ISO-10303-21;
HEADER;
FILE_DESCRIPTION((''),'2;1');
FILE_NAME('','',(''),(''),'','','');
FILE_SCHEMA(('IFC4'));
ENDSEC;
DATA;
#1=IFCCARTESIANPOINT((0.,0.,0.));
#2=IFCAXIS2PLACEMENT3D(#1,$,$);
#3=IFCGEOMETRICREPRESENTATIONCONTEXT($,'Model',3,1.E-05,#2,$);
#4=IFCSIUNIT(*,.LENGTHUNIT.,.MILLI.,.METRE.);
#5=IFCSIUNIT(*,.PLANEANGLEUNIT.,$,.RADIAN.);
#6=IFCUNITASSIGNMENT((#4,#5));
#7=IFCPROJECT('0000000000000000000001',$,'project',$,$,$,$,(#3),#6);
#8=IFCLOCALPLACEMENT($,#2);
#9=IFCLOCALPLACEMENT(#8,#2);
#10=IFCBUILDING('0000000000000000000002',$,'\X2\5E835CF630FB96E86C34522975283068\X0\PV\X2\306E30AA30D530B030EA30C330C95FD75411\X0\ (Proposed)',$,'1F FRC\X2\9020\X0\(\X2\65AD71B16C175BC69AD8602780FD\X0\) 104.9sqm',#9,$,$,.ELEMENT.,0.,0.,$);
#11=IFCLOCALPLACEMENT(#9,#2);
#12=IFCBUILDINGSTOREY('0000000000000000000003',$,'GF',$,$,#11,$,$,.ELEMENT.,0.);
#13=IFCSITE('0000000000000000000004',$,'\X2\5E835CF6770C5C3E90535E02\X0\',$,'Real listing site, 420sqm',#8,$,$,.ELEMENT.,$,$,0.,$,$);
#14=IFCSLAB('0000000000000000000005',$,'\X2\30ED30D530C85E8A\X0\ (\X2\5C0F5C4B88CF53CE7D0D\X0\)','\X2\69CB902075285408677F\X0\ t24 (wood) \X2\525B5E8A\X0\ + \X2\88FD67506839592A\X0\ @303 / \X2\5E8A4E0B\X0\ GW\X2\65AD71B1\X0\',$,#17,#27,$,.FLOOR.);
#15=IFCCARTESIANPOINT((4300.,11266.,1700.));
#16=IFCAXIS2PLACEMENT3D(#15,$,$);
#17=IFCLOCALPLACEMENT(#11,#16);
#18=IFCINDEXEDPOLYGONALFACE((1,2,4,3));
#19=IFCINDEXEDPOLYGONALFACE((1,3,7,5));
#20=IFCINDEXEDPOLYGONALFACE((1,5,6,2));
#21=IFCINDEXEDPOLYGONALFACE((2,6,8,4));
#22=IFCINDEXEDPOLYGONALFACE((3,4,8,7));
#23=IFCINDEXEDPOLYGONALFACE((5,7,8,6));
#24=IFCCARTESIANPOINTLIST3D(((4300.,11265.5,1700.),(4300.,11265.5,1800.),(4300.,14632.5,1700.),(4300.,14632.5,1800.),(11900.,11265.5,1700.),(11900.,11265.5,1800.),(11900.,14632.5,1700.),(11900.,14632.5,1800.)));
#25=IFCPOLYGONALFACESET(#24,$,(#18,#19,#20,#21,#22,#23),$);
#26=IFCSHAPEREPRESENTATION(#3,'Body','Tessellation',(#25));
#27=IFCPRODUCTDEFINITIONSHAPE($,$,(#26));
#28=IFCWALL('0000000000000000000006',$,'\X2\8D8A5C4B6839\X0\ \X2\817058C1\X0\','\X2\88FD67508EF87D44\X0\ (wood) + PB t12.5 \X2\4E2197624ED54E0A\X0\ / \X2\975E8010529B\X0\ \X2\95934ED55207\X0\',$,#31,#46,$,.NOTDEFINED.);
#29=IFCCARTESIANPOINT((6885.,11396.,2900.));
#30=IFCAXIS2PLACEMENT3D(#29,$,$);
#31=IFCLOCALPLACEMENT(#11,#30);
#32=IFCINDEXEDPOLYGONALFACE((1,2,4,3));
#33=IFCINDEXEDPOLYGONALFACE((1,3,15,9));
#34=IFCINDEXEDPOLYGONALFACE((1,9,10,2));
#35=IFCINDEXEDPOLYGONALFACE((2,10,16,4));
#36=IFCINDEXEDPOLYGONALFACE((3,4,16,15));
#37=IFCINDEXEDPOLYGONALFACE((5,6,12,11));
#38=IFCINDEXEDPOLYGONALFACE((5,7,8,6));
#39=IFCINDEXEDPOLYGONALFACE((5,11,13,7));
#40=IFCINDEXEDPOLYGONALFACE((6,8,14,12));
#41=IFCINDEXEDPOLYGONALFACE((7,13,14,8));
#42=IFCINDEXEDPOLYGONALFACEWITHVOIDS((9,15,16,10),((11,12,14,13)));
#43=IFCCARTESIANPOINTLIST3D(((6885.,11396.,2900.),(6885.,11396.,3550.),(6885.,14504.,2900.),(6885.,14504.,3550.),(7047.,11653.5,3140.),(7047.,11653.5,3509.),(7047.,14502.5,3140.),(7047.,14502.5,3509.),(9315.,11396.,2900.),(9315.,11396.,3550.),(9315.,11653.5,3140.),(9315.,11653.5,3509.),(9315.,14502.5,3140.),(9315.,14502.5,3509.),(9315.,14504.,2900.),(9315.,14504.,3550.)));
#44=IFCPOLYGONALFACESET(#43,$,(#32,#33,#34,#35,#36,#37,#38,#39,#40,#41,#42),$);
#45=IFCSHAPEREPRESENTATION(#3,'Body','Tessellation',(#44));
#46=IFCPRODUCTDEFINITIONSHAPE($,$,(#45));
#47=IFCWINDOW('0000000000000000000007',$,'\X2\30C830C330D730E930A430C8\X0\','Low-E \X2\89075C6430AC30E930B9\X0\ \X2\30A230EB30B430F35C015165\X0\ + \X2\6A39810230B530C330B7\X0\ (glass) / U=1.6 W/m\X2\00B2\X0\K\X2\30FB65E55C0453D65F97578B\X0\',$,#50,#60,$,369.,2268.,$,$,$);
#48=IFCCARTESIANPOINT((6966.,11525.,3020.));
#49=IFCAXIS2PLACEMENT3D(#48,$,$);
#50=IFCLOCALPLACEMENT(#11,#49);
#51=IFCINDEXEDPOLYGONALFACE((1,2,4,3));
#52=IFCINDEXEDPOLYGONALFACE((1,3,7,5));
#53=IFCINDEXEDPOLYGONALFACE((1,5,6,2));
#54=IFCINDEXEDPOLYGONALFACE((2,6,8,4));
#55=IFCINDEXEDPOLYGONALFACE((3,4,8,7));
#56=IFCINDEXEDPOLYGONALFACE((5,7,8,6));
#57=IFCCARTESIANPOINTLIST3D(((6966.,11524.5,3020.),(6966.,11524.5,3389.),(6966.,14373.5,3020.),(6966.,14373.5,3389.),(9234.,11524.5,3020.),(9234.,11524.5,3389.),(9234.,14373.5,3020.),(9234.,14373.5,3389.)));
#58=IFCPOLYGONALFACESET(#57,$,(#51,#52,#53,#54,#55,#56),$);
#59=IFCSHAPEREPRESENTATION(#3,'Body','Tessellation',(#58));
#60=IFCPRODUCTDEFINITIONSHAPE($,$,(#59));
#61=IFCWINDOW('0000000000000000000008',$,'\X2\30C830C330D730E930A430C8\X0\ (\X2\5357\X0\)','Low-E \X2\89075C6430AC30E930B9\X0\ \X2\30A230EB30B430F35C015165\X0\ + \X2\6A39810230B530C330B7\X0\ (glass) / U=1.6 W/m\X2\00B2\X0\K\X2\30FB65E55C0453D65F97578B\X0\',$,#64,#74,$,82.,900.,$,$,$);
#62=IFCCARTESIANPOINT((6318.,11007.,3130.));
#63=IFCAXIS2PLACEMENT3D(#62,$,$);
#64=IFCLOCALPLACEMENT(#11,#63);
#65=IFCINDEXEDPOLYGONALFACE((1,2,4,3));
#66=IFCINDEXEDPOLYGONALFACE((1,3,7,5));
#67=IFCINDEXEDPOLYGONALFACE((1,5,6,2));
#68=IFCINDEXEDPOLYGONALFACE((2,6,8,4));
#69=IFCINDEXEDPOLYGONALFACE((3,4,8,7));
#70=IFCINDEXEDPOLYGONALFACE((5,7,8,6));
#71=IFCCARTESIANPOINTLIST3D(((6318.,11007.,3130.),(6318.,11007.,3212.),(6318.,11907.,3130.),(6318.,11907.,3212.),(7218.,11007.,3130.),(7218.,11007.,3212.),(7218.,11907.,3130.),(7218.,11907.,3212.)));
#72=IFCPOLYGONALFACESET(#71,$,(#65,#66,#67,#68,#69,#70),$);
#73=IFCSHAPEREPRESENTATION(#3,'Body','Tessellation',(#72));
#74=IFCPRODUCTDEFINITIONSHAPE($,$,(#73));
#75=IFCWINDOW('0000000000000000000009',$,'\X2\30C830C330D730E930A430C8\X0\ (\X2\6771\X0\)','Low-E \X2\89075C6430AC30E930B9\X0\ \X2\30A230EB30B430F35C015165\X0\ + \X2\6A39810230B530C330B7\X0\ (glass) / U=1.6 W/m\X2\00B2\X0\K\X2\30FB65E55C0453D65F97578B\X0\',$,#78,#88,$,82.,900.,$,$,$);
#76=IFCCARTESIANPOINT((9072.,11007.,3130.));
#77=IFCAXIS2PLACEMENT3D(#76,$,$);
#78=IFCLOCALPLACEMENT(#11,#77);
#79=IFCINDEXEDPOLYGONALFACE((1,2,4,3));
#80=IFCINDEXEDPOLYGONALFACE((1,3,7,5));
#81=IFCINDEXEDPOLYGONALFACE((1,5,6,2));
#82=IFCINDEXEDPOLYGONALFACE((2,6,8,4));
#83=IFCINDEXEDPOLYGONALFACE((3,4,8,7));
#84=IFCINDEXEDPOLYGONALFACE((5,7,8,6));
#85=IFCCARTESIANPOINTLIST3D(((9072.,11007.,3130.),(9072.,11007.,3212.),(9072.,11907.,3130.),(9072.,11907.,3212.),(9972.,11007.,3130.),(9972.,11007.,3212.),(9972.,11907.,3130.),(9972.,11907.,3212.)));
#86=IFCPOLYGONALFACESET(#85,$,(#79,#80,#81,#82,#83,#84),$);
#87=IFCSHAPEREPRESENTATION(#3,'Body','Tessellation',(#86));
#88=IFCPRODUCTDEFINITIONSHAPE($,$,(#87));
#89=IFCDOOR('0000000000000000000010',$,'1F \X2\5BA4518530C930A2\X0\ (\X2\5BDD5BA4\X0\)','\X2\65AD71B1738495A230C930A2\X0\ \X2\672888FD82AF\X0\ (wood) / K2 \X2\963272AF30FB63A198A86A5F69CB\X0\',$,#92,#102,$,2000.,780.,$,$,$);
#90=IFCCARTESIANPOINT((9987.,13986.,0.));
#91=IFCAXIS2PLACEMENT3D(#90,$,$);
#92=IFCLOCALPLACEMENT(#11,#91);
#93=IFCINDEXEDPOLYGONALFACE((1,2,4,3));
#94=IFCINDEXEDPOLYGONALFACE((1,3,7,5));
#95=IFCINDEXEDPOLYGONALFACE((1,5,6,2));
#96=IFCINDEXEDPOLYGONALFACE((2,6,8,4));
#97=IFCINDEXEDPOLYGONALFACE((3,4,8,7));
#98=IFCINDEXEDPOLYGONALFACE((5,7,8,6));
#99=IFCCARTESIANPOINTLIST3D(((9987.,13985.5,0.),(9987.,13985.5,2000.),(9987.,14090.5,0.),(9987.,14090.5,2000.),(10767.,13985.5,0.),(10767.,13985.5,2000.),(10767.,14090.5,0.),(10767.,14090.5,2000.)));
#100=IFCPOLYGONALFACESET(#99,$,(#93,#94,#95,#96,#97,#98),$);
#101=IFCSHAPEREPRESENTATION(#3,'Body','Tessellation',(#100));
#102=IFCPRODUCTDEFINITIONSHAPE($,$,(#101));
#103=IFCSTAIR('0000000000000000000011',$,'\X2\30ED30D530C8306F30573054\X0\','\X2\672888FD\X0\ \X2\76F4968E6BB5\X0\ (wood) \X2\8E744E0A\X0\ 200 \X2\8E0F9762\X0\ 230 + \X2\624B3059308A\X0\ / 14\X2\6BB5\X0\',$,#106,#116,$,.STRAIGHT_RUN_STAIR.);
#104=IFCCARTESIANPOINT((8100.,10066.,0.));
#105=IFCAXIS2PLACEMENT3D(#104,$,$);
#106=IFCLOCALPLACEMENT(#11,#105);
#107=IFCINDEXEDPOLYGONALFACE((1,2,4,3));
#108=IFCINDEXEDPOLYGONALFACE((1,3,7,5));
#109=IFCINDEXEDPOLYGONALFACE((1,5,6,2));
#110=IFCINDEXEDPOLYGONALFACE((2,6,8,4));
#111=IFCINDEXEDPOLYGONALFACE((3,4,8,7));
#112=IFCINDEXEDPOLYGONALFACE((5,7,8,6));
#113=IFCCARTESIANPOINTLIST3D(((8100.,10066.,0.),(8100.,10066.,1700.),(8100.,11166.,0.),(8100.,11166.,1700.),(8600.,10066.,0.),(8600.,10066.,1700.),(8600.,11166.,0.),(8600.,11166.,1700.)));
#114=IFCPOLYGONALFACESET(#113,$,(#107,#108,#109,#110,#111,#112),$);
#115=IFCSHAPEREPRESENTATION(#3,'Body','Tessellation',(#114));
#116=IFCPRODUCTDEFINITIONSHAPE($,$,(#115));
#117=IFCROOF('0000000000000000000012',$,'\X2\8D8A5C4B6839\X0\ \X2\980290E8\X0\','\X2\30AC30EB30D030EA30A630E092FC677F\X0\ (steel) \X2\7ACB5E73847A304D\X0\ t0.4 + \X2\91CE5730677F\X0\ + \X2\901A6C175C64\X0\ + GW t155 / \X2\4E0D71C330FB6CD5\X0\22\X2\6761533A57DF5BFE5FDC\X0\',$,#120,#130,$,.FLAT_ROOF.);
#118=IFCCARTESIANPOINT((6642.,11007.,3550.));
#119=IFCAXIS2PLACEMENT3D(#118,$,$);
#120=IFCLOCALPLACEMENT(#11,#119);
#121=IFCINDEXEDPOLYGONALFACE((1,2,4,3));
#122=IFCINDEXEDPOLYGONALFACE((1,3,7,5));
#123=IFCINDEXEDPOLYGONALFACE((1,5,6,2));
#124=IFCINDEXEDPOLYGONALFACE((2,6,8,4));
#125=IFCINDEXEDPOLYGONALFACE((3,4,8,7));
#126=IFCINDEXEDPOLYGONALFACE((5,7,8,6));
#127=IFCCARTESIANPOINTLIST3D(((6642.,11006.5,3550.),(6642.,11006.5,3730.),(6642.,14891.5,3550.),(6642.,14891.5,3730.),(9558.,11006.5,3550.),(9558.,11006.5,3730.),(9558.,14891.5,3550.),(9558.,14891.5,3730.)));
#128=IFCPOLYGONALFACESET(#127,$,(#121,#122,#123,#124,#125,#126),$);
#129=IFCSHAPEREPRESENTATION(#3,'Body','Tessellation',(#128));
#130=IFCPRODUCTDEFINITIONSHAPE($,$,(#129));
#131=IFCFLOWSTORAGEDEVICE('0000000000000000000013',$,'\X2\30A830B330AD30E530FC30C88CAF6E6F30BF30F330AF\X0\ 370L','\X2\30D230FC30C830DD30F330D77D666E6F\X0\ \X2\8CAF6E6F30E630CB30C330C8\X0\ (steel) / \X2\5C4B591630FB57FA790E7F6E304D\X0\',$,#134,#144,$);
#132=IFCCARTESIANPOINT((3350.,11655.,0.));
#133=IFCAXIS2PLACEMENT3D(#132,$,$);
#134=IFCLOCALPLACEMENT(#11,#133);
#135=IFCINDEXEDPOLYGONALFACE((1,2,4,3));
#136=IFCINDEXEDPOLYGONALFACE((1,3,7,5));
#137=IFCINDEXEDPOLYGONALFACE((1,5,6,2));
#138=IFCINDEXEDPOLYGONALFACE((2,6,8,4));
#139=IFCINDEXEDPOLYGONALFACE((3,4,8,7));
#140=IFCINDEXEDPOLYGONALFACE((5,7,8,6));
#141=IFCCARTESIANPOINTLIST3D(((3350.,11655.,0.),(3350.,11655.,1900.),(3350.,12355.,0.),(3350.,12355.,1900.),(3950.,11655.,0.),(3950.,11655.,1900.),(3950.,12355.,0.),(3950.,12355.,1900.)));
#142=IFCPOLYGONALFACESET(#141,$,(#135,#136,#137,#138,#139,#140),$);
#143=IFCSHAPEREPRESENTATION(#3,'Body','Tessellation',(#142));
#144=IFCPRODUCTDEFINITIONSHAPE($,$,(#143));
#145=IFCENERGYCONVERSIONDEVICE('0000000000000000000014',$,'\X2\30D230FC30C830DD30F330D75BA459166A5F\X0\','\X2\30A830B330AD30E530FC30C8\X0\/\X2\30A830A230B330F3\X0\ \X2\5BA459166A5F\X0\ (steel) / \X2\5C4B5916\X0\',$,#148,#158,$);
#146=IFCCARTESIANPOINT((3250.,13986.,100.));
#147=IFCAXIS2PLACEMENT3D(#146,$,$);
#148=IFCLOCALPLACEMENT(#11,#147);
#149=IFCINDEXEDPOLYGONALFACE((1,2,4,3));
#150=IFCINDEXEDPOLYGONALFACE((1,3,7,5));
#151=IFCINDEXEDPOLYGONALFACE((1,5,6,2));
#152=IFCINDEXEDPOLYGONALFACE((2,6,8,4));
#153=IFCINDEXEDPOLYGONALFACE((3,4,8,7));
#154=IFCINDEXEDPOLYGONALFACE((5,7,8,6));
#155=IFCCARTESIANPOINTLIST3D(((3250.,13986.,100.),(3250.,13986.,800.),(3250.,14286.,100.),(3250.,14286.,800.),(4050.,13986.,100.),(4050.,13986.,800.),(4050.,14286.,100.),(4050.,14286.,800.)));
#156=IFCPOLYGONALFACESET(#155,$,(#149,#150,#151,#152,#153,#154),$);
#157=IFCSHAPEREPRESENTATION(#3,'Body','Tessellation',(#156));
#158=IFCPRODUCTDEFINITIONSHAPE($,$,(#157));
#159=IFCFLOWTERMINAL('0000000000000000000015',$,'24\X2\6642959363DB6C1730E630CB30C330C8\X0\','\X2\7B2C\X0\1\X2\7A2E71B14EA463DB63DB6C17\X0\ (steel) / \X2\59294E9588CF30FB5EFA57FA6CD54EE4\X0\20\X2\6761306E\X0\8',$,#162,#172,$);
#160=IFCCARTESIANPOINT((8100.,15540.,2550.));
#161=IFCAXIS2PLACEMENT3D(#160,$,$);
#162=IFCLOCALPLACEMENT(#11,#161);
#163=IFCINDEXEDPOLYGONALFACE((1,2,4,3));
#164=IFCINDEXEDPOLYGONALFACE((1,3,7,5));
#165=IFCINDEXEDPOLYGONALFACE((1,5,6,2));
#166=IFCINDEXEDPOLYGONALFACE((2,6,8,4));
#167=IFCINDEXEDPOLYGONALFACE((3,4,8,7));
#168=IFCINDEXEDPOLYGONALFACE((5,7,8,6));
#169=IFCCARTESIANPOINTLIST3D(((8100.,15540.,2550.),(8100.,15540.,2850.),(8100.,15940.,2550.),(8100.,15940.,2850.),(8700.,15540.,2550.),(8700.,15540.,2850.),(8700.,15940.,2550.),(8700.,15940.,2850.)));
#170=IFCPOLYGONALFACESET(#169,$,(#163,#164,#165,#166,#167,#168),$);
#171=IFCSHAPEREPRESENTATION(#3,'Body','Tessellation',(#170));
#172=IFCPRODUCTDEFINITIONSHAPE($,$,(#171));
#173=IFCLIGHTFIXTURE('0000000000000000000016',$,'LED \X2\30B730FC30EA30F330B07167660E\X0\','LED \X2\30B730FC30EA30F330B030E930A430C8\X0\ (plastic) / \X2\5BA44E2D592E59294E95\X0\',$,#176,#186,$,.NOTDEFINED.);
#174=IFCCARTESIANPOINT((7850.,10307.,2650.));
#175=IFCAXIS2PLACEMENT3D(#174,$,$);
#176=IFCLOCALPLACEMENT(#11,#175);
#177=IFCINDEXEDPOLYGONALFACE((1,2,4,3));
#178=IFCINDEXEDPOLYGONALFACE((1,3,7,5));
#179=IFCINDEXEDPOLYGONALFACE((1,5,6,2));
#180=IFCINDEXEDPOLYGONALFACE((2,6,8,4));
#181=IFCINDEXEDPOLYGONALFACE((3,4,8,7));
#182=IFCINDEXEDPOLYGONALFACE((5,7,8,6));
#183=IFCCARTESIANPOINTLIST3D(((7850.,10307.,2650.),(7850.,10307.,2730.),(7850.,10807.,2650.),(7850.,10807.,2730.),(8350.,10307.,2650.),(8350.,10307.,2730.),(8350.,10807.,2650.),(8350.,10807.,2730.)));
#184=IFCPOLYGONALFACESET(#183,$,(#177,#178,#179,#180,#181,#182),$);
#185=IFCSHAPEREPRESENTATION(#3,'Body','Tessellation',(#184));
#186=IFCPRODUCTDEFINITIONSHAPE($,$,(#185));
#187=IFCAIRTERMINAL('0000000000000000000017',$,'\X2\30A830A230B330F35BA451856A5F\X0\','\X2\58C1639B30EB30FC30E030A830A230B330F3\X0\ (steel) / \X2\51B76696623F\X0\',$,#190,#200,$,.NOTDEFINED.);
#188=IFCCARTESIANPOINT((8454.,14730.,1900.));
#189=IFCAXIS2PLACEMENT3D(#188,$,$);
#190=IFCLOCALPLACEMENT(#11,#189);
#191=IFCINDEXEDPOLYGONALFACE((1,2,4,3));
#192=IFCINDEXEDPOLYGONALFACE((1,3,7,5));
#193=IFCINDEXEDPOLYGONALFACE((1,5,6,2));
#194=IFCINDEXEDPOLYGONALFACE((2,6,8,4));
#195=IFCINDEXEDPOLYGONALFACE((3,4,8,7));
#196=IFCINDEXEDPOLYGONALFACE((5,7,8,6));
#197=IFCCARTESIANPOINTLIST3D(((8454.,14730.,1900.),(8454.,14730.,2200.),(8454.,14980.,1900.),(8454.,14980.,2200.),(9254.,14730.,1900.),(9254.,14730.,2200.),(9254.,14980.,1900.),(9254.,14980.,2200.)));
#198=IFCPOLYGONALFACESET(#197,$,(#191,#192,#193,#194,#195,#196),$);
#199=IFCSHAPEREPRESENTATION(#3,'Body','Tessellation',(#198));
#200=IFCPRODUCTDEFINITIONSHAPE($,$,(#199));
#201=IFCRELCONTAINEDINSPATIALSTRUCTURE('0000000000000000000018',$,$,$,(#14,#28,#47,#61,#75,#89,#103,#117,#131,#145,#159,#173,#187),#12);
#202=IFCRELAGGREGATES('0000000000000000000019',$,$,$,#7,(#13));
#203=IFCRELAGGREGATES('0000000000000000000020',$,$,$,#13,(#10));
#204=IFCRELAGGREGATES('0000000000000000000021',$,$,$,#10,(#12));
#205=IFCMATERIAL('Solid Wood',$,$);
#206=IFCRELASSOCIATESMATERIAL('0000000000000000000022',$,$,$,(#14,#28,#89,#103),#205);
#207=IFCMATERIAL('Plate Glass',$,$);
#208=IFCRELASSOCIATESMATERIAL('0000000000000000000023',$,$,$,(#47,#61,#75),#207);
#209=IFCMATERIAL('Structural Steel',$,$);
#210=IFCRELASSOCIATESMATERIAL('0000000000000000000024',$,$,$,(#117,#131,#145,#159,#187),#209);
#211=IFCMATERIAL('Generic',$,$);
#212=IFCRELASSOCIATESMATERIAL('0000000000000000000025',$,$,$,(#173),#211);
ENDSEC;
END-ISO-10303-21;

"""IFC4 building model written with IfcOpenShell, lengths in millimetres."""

from ifc_helpers import new_model, si_unit, frame, frame_2d, origin, place, context, project, spatial, rectangle, extrude, material, element, fill, save


model = new_model("IFC4")

# Units and contexts
model_context = context("Model", 3, precision=1e-05, world=origin())
ifc_project = project(units=[si_unit("LENGTHUNIT", "METRE", prefix="MILLI"), si_unit("PLANEANGLEUNIT", "RADIAN")], contexts=[model_context])

# Site, building, storey
site_placement = place(None, origin())
site = spatial("IfcSite", under=ifc_project, at=site_placement, Name="広島県尾道市", ObjectType="Real listing site, 420sqm", CompositionType="ELEMENT", RefElevation=0.0)
building_placement = place(site_placement, origin())
building = spatial("IfcBuilding", under=site, at=building_placement, Name="広島・雨水利用とPVのオフグリッド志向 (Proposed)", ObjectType="1F FRC造(断熱気密高性能) 104.9sqm", CompositionType="ELEMENT", ElevationOfRefHeight=0.0, ElevationOfTerrain=0.0)
storey_placement = place(building_placement, origin())
storey = spatial("IfcBuildingStorey", under=building, at=storey_placement, Name="GF", CompositionType="ELEMENT", Elevation=0.0)

# Shared definitions
ifc_material_1 = material(Name="Solid Wood")

# Slab
slab_placement = place(storey_placement, frame((4300.0, 11266.0, 1700.0)))
element("IfcSlab", 1, at=slab_placement, inside=storey, material=ifc_material_1, Name="ロフト床 (小屋裏収納)", Description="構造用合板 t24 (wood) 剛床 + 製材根太 @303 / 床下 GW断熱", PredefinedType="FLOOR", context=model_context, shape_type="SweptSolid", body=[
    extrude(rectangle(XDim=7600.0, YDim=3367.0, at=frame_2d((3800.0, 1683.0))), frame((4300.0, 11266.0, 1700.0)), (0.0, 0.0, 1.0), 100.0),
])

# Wall, openings, windows
wall_1_placement = place(storey_placement, frame((6885.0, 11396.0, 2900.0)))
wall_1 = element("IfcWall", 2, at=wall_1_placement, inside=storey, material=ifc_material_1, Name="越屋根 腰壁", Description="製材軸組 (wood) + PB t12.5 両面仕上 / 非耐力 間仕切", PredefinedType="NOTDEFINED", context=model_context, shape_type="SweptSolid", body=[
    extrude(rectangle(XDim=2430.0, YDim=3108.0, at=frame_2d((1215.0, 1554.0))), frame((6885.0, 11396.0, 2900.0)), (0.0, 0.0, 1.0), 650.0),
])
opening_1_placement = place(storey_placement, frame((6966.0, 11525.0, 3020.0)))
opening_1 = element("IfcOpeningElement", 3, at=opening_1_placement, cuts=wall_1, PredefinedType="NOTDEFINED", context=model_context, shape_type="SweptSolid", body=[
    extrude(rectangle(XDim=2268.0, YDim=2849.0, at=frame_2d((1134.0, 1424.0))), frame((6966.0, 11525.0, 3020.0)), (0.0, 0.0, 1.0), 369.0),
])
opening_2_placement = place(storey_placement, frame((6318.0, 11007.0, 3130.0)))
opening_2 = element("IfcOpeningElement", 4, at=opening_2_placement, cuts=wall_1, PredefinedType="NOTDEFINED", context=model_context, shape_type="SweptSolid", body=[
    extrude(rectangle(XDim=900.0, YDim=900.0, at=frame_2d((450.0, 450.0))), frame((6318.0, 11007.0, 3130.0)), (0.0, 0.0, 1.0), 82.0),
])
opening_3_placement = place(storey_placement, frame((9072.0, 11007.0, 3130.0)))
opening_3 = element("IfcOpeningElement", 5, at=opening_3_placement, cuts=wall_1, PredefinedType="NOTDEFINED", context=model_context, shape_type="SweptSolid", body=[
    extrude(rectangle(XDim=900.0, YDim=900.0, at=frame_2d((450.0, 450.0))), frame((9072.0, 11007.0, 3130.0)), (0.0, 0.0, 1.0), 82.0),
])
ifc_material_2 = material(Name="Plate Glass")
window_1_placement = place(storey_placement, frame((6966.0, 11525.0, 3020.0)))
window_1 = element("IfcWindow", 6, at=window_1_placement, inside=storey, material=ifc_material_2, Name="トップライト", Description="Low-E 複層ガラス アルゴン封入 + 樹脂サッシ (glass) / U=1.6 W/m²K・日射取得型", OverallHeight=369.0, OverallWidth=2268.0, context=model_context, shape_type="SweptSolid", body=[
    extrude(rectangle(XDim=2268.0, YDim=2849.0, at=frame_2d((1134.0, 1424.0))), frame((6966.0, 11525.0, 3020.0)), (0.0, 0.0, 1.0), 369.0),
])
fill(opening_1, window_1)
window_2_placement = place(storey_placement, frame((6318.0, 11007.0, 3130.0)))
window_2 = element("IfcWindow", 7, at=window_2_placement, inside=storey, material=ifc_material_2, Name="トップライト (南)", Description="Low-E 複層ガラス アルゴン封入 + 樹脂サッシ (glass) / U=1.6 W/m²K・日射取得型", OverallHeight=82.0, OverallWidth=900.0, context=model_context, shape_type="SweptSolid", body=[
    extrude(rectangle(XDim=900.0, YDim=900.0, at=frame_2d((450.0, 450.0))), frame((6318.0, 11007.0, 3130.0)), (0.0, 0.0, 1.0), 82.0),
])
fill(opening_2, window_2)
window_3_placement = place(storey_placement, frame((9072.0, 11007.0, 3130.0)))
window_3 = element("IfcWindow", 8, at=window_3_placement, inside=storey, material=ifc_material_2, Name="トップライト (東)", Description="Low-E 複層ガラス アルゴン封入 + 樹脂サッシ (glass) / U=1.6 W/m²K・日射取得型", OverallHeight=82.0, OverallWidth=900.0, context=model_context, shape_type="SweptSolid", body=[
    extrude(rectangle(XDim=900.0, YDim=900.0, at=frame_2d((450.0, 450.0))), frame((9072.0, 11007.0, 3130.0)), (0.0, 0.0, 1.0), 82.0),
])
fill(opening_3, window_3)

# Door
door_1_placement = place(storey_placement, frame((9987.0, 13986.0, 0.0)))
element("IfcDoor", 9, at=door_1_placement, inside=storey, material=ifc_material_1, Name="1F 室内ドア (寝室)", Description="断熱玄関ドア 木製芯 (wood) / K2 防犯・採風機構", OverallHeight=2000.0, OverallWidth=780.0, context=model_context, shape_type="SweptSolid", body=[
    extrude(rectangle(XDim=780.0, YDim=105.0, at=frame_2d((390.0, 52.0))), frame((9987.0, 13986.0, 0.0)), (0.0, 0.0, 1.0), 2000.0),
])

# Stair
stair_placement = place(storey_placement, frame((8100.0, 10066.0, 0.0)))
element("IfcStair", 10, at=stair_placement, inside=storey, material=ifc_material_1, Name="ロフトはしご", Description="木製 直階段 (wood) 蹴上 200 踏面 230 + 手すり / 14段", PredefinedType="STRAIGHT_RUN_STAIR", context=model_context, shape_type="SweptSolid", body=[
    extrude(rectangle(XDim=500.0, YDim=1100.0, at=frame_2d((250.0, 550.0))), frame((8100.0, 10066.0, 0.0)), (0.0, 0.0, 1.0), 1700.0),
])

# Roof
ifc_material_3 = material(Name="Structural Steel")
roof_placement = place(storey_placement, frame((6642.0, 11007.0, 3550.0)))
element("IfcRoof", 11, at=roof_placement, inside=storey, material=ifc_material_3, Name="越屋根 頂部", Description="ガルバリウム鋼板 (steel) 立平葺き t0.4 + 野地板 + 通気層 + GW t155 / 不燃・法22条区域対応", PredefinedType="FLAT_ROOF", context=model_context, shape_type="SweptSolid", body=[
    extrude(rectangle(XDim=2916.0, YDim=3885.0, at=frame_2d((1458.0, 1942.0))), frame((6642.0, 11007.0, 3550.0)), (0.0, 0.0, 1.0), 180.0),
])

# Flow storage device
flow_storage_device_placement = place(storey_placement, frame((3350.0, 11655.0, 0.0)))
element("IfcFlowStorageDevice", 12, at=flow_storage_device_placement, inside=storey, material=ifc_material_3, Name="エコキュート貯湯タンク 370L", Description="ヒートポンプ給湯 貯湯ユニット (steel) / 屋外・基礎置き", context=model_context, shape_type="SweptSolid", body=[
    extrude(rectangle(XDim=600.0, YDim=700.0, at=frame_2d((300.0, 350.0))), frame((3350.0, 11655.0, 0.0)), (0.0, 0.0, 1.0), 1900.0),
])

# Energy conversion device
energy_conversion_device_placement = place(storey_placement, frame((3250.0, 13986.0, 100.0)))
element("IfcEnergyConversionDevice", 13, at=energy_conversion_device_placement, inside=storey, material=ifc_material_3, Name="ヒートポンプ室外機", Description="エコキュート/エアコン 室外機 (steel) / 屋外", context=model_context, shape_type="SweptSolid", body=[
    extrude(rectangle(XDim=800.0, YDim=300.0, at=frame_2d((400.0, 150.0))), frame((3250.0, 13986.0, 100.0)), (0.0, 0.0, 1.0), 700.0),
])

# Flow terminal
flow_terminal_placement = place(storey_placement, frame((8100.0, 15540.0, 2550.0)))
element("IfcFlowTerminal", 14, at=flow_terminal_placement, inside=storey, material=ifc_material_3, Name="24時間換気ユニット", Description="第1種熱交換換気 (steel) / 天井裏・建基法令20条の8", context=model_context, shape_type="SweptSolid", body=[
    extrude(rectangle(XDim=600.0, YDim=400.0, at=frame_2d((300.0, 200.0))), frame((8100.0, 15540.0, 2550.0)), (0.0, 0.0, 1.0), 300.0),
])

# Light fixture
ifc_material_4 = material(Name="Generic")
light_fixture_placement = place(storey_placement, frame((7850.0, 10307.0, 2650.0)))
element("IfcLightFixture", 15, at=light_fixture_placement, inside=storey, material=ifc_material_4, Name="LED シーリング照明", Description="LED シーリングライト (plastic) / 室中央天井", PredefinedType="NOTDEFINED", context=model_context, shape_type="SweptSolid", body=[
    extrude(rectangle(XDim=500.0, YDim=500.0, at=frame_2d((250.0, 250.0))), frame((7850.0, 10307.0, 2650.0)), (0.0, 0.0, 1.0), 80.0),
])

# Air terminal
air_terminal_placement = place(storey_placement, frame((8454.0, 14730.0, 1900.0)))
element("IfcAirTerminal", 16, at=air_terminal_placement, inside=storey, material=ifc_material_3, Name="エアコン室内機", Description="壁掛ルームエアコン (steel) / 冷暖房", PredefinedType="NOTDEFINED", context=model_context, shape_type="SweptSolid", body=[
    extrude(rectangle(XDim=800.0, YDim=250.0, at=frame_2d((400.0, 125.0))), frame((8454.0, 14730.0, 1900.0)), (0.0, 0.0, 1.0), 300.0),
])

save(model, "model.ifc")
